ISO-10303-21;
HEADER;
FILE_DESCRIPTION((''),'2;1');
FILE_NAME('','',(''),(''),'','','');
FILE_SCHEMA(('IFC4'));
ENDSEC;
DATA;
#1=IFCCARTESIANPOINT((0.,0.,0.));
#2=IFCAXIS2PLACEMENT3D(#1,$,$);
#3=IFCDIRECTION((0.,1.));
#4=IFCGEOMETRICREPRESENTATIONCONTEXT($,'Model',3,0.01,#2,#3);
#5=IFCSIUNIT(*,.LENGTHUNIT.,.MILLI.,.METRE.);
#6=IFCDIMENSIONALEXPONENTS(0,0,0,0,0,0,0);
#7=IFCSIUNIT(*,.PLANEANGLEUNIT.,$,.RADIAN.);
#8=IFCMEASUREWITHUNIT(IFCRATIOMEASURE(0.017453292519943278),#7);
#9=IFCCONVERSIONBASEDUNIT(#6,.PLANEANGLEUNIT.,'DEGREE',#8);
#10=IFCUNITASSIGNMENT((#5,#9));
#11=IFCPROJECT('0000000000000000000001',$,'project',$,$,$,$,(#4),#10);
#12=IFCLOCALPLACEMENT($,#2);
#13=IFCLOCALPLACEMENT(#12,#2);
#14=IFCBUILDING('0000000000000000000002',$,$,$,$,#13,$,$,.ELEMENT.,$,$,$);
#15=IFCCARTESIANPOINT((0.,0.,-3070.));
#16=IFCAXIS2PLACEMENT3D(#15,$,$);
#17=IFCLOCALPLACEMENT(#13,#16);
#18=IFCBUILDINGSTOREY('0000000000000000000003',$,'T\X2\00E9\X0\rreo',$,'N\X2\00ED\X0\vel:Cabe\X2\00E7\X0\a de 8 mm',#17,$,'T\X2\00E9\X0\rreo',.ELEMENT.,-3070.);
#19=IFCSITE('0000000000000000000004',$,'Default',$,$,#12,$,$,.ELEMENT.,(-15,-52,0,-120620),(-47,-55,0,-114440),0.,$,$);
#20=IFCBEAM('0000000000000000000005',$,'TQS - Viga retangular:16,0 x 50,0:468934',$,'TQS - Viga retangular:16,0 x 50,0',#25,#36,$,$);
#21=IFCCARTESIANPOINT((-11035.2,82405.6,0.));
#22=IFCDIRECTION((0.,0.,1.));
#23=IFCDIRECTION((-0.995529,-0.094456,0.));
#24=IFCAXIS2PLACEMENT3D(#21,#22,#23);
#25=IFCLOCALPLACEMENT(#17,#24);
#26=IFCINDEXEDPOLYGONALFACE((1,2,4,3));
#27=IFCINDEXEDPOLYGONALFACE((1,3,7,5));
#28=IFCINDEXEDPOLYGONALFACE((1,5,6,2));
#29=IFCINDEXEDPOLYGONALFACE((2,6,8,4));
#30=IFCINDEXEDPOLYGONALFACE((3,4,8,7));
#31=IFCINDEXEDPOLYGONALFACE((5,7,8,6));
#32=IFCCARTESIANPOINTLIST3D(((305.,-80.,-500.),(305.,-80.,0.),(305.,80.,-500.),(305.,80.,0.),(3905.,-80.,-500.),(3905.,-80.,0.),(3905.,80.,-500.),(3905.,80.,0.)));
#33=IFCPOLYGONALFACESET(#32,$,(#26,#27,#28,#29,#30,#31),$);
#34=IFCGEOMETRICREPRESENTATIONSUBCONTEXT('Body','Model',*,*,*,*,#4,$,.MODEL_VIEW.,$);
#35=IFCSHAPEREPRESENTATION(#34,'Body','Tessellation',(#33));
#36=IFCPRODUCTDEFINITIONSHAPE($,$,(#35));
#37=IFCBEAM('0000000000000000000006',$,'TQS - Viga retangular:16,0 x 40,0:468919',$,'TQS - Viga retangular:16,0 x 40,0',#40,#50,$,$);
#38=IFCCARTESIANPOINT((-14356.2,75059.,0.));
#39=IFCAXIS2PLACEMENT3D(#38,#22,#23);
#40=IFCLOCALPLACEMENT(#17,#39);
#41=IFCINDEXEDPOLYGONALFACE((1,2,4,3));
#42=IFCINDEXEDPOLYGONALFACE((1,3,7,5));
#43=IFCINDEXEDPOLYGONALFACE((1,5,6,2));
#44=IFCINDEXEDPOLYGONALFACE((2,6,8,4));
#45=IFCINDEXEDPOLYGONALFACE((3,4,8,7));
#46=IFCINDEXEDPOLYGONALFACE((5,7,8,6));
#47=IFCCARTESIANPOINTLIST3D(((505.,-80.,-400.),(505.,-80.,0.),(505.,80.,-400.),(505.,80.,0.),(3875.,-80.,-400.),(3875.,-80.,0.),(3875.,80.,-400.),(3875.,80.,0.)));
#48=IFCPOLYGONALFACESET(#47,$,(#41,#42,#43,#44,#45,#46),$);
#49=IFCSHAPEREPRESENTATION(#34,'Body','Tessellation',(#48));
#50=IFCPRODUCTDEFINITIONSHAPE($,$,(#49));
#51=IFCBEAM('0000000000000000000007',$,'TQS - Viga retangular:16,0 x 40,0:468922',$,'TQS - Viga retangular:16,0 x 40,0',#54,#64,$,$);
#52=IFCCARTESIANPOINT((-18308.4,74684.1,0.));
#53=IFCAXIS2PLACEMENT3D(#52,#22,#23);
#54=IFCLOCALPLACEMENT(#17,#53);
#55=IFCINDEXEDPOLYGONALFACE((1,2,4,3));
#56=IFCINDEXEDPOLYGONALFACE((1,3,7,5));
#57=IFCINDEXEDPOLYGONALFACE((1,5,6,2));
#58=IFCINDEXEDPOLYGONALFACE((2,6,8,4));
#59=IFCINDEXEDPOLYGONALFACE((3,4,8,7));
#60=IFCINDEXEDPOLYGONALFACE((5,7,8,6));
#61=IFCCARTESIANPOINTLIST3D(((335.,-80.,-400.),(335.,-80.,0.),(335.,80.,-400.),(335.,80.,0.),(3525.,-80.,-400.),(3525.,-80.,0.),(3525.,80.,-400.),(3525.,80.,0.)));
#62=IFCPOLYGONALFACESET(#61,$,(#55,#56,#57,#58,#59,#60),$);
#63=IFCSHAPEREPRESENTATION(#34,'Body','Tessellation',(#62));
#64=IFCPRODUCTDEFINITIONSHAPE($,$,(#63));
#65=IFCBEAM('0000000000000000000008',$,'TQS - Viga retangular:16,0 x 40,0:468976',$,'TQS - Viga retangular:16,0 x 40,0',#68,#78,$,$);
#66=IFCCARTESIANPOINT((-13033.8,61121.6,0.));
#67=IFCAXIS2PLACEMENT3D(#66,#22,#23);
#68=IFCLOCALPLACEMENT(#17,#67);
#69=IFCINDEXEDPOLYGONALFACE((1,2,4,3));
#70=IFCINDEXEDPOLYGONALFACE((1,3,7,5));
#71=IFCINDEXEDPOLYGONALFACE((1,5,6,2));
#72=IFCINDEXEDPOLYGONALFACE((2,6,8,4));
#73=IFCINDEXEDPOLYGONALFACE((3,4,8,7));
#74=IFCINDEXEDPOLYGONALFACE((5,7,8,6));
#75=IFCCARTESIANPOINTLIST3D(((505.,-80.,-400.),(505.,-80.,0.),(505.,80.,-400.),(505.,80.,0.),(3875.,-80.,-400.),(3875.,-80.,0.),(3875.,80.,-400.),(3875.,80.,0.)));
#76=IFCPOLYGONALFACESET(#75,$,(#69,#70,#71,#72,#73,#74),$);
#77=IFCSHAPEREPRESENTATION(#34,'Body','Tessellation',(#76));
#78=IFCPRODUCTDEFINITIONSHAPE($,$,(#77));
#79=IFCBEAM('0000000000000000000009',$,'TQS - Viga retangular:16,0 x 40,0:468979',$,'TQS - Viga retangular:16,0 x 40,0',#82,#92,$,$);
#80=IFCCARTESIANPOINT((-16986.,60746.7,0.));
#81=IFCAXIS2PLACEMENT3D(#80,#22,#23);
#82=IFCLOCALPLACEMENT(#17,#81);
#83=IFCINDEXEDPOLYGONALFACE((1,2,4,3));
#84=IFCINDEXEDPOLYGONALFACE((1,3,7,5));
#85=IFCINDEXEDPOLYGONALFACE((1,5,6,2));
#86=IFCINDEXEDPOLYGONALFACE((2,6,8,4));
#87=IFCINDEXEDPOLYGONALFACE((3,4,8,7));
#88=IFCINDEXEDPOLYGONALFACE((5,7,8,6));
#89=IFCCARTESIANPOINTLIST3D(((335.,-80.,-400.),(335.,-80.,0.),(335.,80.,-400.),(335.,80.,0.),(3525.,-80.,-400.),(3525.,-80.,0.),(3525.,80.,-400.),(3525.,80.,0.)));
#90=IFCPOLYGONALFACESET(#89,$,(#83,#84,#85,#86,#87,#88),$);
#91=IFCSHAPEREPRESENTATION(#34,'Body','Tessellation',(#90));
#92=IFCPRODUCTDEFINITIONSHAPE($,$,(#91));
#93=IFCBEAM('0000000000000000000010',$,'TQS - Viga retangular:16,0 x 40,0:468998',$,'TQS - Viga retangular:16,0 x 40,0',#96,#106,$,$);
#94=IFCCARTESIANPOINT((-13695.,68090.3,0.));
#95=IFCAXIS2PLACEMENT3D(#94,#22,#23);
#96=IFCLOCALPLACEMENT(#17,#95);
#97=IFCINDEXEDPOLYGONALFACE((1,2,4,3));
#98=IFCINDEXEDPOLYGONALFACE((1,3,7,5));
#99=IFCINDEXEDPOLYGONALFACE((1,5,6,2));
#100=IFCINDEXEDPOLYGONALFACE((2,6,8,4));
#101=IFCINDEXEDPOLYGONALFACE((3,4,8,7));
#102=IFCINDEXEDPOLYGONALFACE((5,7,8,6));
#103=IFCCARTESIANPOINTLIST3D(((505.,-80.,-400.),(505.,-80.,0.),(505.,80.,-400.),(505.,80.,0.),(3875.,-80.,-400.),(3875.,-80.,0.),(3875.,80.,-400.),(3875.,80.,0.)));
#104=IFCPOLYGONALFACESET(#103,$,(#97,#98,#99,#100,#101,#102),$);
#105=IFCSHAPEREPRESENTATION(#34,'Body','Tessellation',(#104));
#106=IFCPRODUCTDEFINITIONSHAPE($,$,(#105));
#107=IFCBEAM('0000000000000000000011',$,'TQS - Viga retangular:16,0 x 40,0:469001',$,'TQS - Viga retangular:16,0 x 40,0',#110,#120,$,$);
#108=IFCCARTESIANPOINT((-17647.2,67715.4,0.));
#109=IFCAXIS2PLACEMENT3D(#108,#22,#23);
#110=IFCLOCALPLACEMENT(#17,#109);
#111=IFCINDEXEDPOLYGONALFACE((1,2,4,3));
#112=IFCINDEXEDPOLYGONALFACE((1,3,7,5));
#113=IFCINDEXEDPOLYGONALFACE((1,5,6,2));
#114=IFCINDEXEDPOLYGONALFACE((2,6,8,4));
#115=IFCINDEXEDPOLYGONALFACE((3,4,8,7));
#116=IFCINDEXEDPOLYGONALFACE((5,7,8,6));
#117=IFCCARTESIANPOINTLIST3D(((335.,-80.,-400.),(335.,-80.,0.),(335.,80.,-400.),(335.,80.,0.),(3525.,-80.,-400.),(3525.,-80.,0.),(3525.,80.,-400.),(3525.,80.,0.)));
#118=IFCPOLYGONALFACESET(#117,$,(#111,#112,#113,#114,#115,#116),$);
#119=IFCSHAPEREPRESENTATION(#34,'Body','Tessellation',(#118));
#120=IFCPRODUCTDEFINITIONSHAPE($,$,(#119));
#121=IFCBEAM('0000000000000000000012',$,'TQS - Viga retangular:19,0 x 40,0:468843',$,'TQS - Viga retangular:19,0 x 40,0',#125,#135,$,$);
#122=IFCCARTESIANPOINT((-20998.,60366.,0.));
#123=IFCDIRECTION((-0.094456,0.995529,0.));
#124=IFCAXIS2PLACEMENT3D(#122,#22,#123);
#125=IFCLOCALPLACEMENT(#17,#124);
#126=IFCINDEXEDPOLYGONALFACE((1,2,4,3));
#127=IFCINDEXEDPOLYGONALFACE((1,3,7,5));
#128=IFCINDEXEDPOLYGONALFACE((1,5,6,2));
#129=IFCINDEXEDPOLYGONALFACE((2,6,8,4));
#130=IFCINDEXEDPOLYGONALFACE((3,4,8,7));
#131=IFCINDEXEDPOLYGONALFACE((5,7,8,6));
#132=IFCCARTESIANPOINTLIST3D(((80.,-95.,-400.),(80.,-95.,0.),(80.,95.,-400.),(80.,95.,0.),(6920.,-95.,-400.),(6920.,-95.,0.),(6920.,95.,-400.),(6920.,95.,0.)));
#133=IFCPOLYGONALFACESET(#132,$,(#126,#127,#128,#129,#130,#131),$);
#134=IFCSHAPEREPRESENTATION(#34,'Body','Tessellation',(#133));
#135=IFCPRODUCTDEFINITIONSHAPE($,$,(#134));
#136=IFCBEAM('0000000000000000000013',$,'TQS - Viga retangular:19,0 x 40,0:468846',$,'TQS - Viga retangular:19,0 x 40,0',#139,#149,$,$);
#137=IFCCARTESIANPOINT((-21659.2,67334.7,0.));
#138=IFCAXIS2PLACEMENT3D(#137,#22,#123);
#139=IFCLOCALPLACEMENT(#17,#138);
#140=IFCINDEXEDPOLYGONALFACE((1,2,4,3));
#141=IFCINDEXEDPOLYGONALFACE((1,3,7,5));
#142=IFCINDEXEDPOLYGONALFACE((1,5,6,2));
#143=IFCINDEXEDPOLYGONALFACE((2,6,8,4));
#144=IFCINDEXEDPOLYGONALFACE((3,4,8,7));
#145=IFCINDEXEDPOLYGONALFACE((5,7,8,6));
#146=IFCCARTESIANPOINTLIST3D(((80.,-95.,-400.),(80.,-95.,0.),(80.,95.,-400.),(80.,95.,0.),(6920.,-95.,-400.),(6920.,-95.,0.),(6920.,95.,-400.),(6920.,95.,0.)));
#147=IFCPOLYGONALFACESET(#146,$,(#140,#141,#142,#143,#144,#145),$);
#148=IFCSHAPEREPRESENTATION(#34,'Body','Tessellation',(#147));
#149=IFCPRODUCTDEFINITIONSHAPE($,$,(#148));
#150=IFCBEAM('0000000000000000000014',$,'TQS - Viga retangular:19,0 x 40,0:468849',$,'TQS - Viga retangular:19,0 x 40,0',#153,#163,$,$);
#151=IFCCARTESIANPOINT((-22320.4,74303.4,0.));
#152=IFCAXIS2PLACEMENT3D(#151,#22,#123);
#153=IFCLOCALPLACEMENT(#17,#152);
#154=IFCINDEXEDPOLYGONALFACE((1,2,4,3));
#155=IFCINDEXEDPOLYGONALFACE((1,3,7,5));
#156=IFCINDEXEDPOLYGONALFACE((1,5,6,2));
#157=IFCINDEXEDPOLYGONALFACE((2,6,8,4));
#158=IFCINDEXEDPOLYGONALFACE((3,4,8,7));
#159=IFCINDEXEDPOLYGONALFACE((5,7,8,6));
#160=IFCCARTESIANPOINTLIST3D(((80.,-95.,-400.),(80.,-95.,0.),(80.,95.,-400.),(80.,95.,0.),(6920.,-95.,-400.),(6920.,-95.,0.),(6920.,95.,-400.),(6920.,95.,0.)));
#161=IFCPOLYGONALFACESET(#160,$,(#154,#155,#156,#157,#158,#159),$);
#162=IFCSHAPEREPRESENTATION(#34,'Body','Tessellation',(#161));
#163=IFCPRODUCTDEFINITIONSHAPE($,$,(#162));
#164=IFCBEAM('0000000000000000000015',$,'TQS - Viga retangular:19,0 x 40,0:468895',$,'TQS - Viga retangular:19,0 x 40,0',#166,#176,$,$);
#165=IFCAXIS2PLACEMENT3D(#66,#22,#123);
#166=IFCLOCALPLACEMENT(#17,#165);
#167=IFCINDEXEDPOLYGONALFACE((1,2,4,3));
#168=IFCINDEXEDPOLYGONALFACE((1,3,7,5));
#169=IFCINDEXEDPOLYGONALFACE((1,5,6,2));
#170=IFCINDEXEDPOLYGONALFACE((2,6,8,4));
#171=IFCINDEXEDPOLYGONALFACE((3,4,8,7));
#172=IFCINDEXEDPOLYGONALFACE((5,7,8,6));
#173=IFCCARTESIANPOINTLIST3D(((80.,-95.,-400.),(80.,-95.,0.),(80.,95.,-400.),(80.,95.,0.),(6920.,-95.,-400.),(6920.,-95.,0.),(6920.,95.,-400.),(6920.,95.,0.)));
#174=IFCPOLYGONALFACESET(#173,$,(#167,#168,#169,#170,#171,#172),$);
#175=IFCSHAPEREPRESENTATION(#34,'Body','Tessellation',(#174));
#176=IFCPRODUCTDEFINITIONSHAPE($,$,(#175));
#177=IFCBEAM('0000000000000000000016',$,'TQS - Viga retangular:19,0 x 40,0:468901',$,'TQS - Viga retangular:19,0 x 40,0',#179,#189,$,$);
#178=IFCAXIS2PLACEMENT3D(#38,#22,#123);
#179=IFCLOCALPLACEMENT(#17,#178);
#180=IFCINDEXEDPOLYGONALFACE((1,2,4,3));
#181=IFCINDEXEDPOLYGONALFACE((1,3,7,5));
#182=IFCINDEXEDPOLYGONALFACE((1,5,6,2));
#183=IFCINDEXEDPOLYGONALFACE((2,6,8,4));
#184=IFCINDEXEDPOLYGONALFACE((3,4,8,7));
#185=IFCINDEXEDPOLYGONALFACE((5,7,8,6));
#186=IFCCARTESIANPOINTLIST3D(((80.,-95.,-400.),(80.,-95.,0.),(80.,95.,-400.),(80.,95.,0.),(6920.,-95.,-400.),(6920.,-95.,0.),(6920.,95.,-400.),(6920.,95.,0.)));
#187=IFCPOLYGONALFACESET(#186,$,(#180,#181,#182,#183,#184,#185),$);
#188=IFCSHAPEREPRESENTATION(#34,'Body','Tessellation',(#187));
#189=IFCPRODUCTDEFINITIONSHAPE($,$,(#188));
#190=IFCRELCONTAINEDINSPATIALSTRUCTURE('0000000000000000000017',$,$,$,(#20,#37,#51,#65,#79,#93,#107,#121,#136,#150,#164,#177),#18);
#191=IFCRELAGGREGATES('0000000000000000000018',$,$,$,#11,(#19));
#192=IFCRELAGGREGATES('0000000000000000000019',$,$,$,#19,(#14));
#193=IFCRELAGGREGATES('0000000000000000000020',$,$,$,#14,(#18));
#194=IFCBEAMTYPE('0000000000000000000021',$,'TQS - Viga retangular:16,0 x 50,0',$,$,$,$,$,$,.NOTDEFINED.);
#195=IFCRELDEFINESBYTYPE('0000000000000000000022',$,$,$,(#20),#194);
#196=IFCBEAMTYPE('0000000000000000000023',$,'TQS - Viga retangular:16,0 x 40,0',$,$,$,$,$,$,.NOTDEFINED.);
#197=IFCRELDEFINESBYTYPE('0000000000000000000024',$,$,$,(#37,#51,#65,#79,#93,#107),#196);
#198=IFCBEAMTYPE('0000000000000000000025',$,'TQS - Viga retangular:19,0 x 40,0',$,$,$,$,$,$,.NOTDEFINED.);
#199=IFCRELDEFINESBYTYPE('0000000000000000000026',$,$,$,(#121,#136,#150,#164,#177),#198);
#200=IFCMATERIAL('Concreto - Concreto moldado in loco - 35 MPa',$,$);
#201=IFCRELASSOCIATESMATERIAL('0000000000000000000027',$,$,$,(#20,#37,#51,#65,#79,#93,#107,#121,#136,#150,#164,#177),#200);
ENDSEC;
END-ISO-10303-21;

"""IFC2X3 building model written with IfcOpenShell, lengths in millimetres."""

from ifc_helpers import new_model, entity, si_unit, converted_unit, direction, frame, frame_2d, origin, origin_2d_with_axis, place, context, subcontext, project, spatial, rectangle, extrude, material, type_object, element, save


model = new_model("IFC2X3")

# Units and contexts
model_context = context("Model", 3, precision=0.01, world=origin(), true_north=direction((0.0, 1.0)))
body_context = subcontext(model_context, "Body", "Model", "MODEL_VIEW")
ifc_project = project(units=[si_unit("LENGTHUNIT", "METRE", prefix="MILLI"), converted_unit("PLANEANGLEUNIT", "DEGREE", entity("IfcRatioMeasure", 0.017453292519943278), si_unit("PLANEANGLEUNIT", "RADIAN"), dimensions=[0, 0, 0, 0, 0, 0, 0])], contexts=[model_context])

# Site, building, storey
site_placement = place(None, origin())
site = spatial("IfcSite", under=ifc_project, at=site_placement, Name="Default", CompositionType="ELEMENT", RefLatitude=(-15, -52, 0, -120620), RefLongitude=(-47, -55, 0, -114440), RefElevation=0.0)
building_placement = place(site_placement, origin())
building = spatial("IfcBuilding", under=site, at=building_placement, CompositionType="ELEMENT")
storey_placement = place(building_placement, frame((0.0, 0.0, -3070.0)))
storey = spatial("IfcBuildingStorey", under=building, at=storey_placement, Name="Térreo", ObjectType="Nível:Cabeça de 8 mm", LongName="Térreo", CompositionType="ELEMENT", Elevation=-3070.0)

# Beams
ifc_material_1 = material(Name="Concreto - Concreto moldado in loco - 35 MPa")
beam_type_1 = type_object("IfcBeamType", Name="TQS - Viga retangular:16,0 x 50,0", PredefinedType="NOTDEFINED")
beam_1_placement = place(storey_placement, frame((-11035.2, 82405.6, 0.0), z_axis=(0.0, 0.0, 1.0), x_axis=(-0.995529, -0.094456, 0.0)))
element("IfcBeam", 1, at=beam_1_placement, inside=storey, type_object=beam_type_1, material=ifc_material_1, Name="TQS - Viga retangular:16,0 x 50,0:468934", ObjectType="TQS - Viga retangular:16,0 x 50,0", context=body_context, shape_type="SweptSolid", body=[
    extrude(rectangle(XDim=500.0, YDim=160.0, at=frame_2d((0.0, 0.0), x_axis=(1.0, 0.0))), frame((305.0, 0.0, -250.0), z_axis=(1.0, 0.0, 0.0), x_axis=(0.0, 0.0, -1.0)), (0.0, 0.0, 1.0), 3600.0),
])
beam_type_2 = type_object("IfcBeamType", Name="TQS - Viga retangular:16,0 x 40,0", PredefinedType="NOTDEFINED")
beam_2_placement = place(storey_placement, frame((-14356.2, 75059.0, 0.0), z_axis=(0.0, 0.0, 1.0), x_axis=(-0.995529, -0.094456, 0.0)))
element("IfcBeam", 2, at=beam_2_placement, inside=storey, type_object=beam_type_2, material=ifc_material_1, Name="TQS - Viga retangular:16,0 x 40,0:468919", ObjectType="TQS - Viga retangular:16,0 x 40,0", context=body_context, shape_type="SweptSolid", body=[
    extrude(rectangle(XDim=400.0, YDim=160.0, at=frame_2d((0.0, 0.0), x_axis=(1.0, 0.0))), frame((505.0, 0.0, -200.0), z_axis=(1.0, 0.0, 0.0), x_axis=(0.0, 0.0, -1.0)), (0.0, 0.0, 1.0), 3370.0),
])
beam_3_placement = place(storey_placement, frame((-18308.4, 74684.1, 0.0), z_axis=(0.0, 0.0, 1.0), x_axis=(-0.995529, -0.094456, 0.0)))
element("IfcBeam", 3, at=beam_3_placement, inside=storey, type_object=beam_type_2, material=ifc_material_1, Name="TQS - Viga retangular:16,0 x 40,0:468922", ObjectType="TQS - Viga retangular:16,0 x 40,0", context=body_context, shape_type="SweptSolid", body=[
    extrude(rectangle(XDim=400.0, YDim=160.0, at=origin_2d_with_axis()), frame((335.0, 0.0, -200.0), z_axis=(1.0, 0.0, 0.0), x_axis=(0.0, 0.0, -1.0)), (0.0, 0.0, 1.0), 3190.0),
])
beam_4_placement = place(storey_placement, frame((-13033.8, 61121.6, 0.0), z_axis=(0.0, 0.0, 1.0), x_axis=(-0.995529, -0.094456, 0.0)))
element("IfcBeam", 4, at=beam_4_placement, inside=storey, type_object=beam_type_2, material=ifc_material_1, Name="TQS - Viga retangular:16,0 x 40,0:468976", ObjectType="TQS - Viga retangular:16,0 x 40,0", context=body_context, shape_type="SweptSolid", body=[
    extrude(rectangle(XDim=400.0, YDim=160.0, at=frame_2d((0.0, 0.0), x_axis=(1.0, 0.0))), frame((505.0, 0.0, -200.0), z_axis=(1.0, 0.0, 0.0), x_axis=(0.0, 0.0, -1.0)), (0.0, 0.0, 1.0), 3370.0),
])
beam_5_placement = place(storey_placement, frame((-16986.0, 60746.7, 0.0), z_axis=(0.0, 0.0, 1.0), x_axis=(-0.995529, -0.094456, 0.0)))
element("IfcBeam", 5, at=beam_5_placement, inside=storey, type_object=beam_type_2, material=ifc_material_1, Name="TQS - Viga retangular:16,0 x 40,0:468979", ObjectType="TQS - Viga retangular:16,0 x 40,0", context=body_context, shape_type="SweptSolid", body=[
    extrude(rectangle(XDim=400.0, YDim=160.0, at=frame_2d((0.0, 0.0), x_axis=(1.0, 0.0))), frame((335.0, 0.0, -200.0), z_axis=(1.0, 0.0, 0.0), x_axis=(0.0, 0.0, -1.0)), (0.0, 0.0, 1.0), 3190.0),
])
beam_6_placement = place(storey_placement, frame((-13695.0, 68090.3, 0.0), z_axis=(0.0, 0.0, 1.0), x_axis=(-0.995529, -0.094456, 0.0)))
element("IfcBeam", 6, at=beam_6_placement, inside=storey, type_object=beam_type_2, material=ifc_material_1, Name="TQS - Viga retangular:16,0 x 40,0:468998", ObjectType="TQS - Viga retangular:16,0 x 40,0", context=body_context, shape_type="SweptSolid", body=[
    extrude(rectangle(XDim=400.0, YDim=160.0, at=frame_2d((0.0, 0.0), x_axis=(1.0, 0.0))), frame((505.0, 0.0, -200.0), z_axis=(1.0, 0.0, 0.0), x_axis=(0.0, 0.0, -1.0)), (0.0, 0.0, 1.0), 3370.0),
])
beam_7_placement = place(storey_placement, frame((-17647.2, 67715.4, 0.0), z_axis=(0.0, 0.0, 1.0), x_axis=(-0.995529, -0.094456, 0.0)))
element("IfcBeam", 7, at=beam_7_placement, inside=storey, type_object=beam_type_2, material=ifc_material_1, Name="TQS - Viga retangular:16,0 x 40,0:469001", ObjectType="TQS - Viga retangular:16,0 x 40,0", context=body_context, shape_type="SweptSolid", body=[
    extrude(rectangle(XDim=400.0, YDim=160.0, at=frame_2d((0.0, 0.0), x_axis=(1.0, 0.0))), frame((335.0, 0.0, -200.0), z_axis=(1.0, 0.0, 0.0), x_axis=(0.0, 0.0, -1.0)), (0.0, 0.0, 1.0), 3190.0),
])
beam_type_3 = type_object("IfcBeamType", Name="TQS - Viga retangular:19,0 x 40,0", PredefinedType="NOTDEFINED")
beam_8_placement = place(storey_placement, frame((-20998.0, 60366.0, 0.0), z_axis=(0.0, 0.0, 1.0), x_axis=(-0.094456, 0.995529, 0.0)))
element("IfcBeam", 8, at=beam_8_placement, inside=storey, type_object=beam_type_3, material=ifc_material_1, Name="TQS - Viga retangular:19,0 x 40,0:468843", ObjectType="TQS - Viga retangular:19,0 x 40,0", context=body_context, shape_type="SweptSolid", body=[
    extrude(rectangle(XDim=400.0, YDim=190.0, at=frame_2d((0.0, 0.0), x_axis=(1.0, 0.0))), frame((80.0, 0.0, -200.0), z_axis=(1.0, 0.0, 0.0), x_axis=(0.0, 0.0, -1.0)), (0.0, 0.0, 1.0), 6840.0),
])
beam_9_placement = place(storey_placement, frame((-21659.2, 67334.7, 0.0), z_axis=(0.0, 0.0, 1.0), x_axis=(-0.094456, 0.995529, 0.0)))
element("IfcBeam", 9, at=beam_9_placement, inside=storey, type_object=beam_type_3, material=ifc_material_1, Name="TQS - Viga retangular:19,0 x 40,0:468846", ObjectType="TQS - Viga retangular:19,0 x 40,0", context=body_context, shape_type="SweptSolid", body=[
    extrude(rectangle(XDim=400.0, YDim=190.0, at=frame_2d((0.0, 0.0), x_axis=(1.0, 0.0))), frame((80.0, 0.0, -200.0), z_axis=(1.0, 0.0, 0.0), x_axis=(0.0, 0.0, -1.0)), (0.0, 0.0, 1.0), 6840.0),
])
beam_10_placement = place(storey_placement, frame((-22320.4, 74303.4, 0.0), z_axis=(0.0, 0.0, 1.0), x_axis=(-0.094456, 0.995529, 0.0)))
element("IfcBeam", 10, at=beam_10_placement, inside=storey, type_object=beam_type_3, material=ifc_material_1, Name="TQS - Viga retangular:19,0 x 40,0:468849", ObjectType="TQS - Viga retangular:19,0 x 40,0", context=body_context, shape_type="SweptSolid", body=[
    extrude(rectangle(XDim=400.0, YDim=190.0, at=origin_2d_with_axis()), frame((80.0, 0.0, -200.0), z_axis=(1.0, 0.0, 0.0), x_axis=(0.0, 0.0, -1.0)), (0.0, 0.0, 1.0), 6840.0),
])
beam_11_placement = place(storey_placement, frame((-13033.8, 61121.6, 0.0), z_axis=(0.0, 0.0, 1.0), x_axis=(-0.094456, 0.995529, 0.0)))
element("IfcBeam", 11, at=beam_11_placement, inside=storey, type_object=beam_type_3, material=ifc_material_1, Name="TQS - Viga retangular:19,0 x 40,0:468895", ObjectType="TQS - Viga retangular:19,0 x 40,0", context=body_context, shape_type="SweptSolid", body=[
    extrude(rectangle(XDim=400.0, YDim=190.0, at=origin_2d_with_axis()), frame((80.0, 0.0, -200.0), z_axis=(1.0, 0.0, 0.0), x_axis=(0.0, 0.0, -1.0)), (0.0, 0.0, 1.0), 6840.0),
])
beam_12_placement = place(storey_placement, frame((-14356.2, 75059.0, 0.0), z_axis=(0.0, 0.0, 1.0), x_axis=(-0.094456, 0.995529, 0.0)))
element("IfcBeam", 12, at=beam_12_placement, inside=storey, type_object=beam_type_3, material=ifc_material_1, Name="TQS - Viga retangular:19,0 x 40,0:468901", ObjectType="TQS - Viga retangular:19,0 x 40,0", context=body_context, shape_type="SweptSolid", body=[
    extrude(rectangle(XDim=400.0, YDim=190.0, at=origin_2d_with_axis()), frame((80.0, 0.0, -200.0), z_axis=(1.0, 0.0, 0.0), x_axis=(0.0, 0.0, -1.0)), (0.0, 0.0, 1.0), 6840.0),
])

save(model, "model.ifc")
